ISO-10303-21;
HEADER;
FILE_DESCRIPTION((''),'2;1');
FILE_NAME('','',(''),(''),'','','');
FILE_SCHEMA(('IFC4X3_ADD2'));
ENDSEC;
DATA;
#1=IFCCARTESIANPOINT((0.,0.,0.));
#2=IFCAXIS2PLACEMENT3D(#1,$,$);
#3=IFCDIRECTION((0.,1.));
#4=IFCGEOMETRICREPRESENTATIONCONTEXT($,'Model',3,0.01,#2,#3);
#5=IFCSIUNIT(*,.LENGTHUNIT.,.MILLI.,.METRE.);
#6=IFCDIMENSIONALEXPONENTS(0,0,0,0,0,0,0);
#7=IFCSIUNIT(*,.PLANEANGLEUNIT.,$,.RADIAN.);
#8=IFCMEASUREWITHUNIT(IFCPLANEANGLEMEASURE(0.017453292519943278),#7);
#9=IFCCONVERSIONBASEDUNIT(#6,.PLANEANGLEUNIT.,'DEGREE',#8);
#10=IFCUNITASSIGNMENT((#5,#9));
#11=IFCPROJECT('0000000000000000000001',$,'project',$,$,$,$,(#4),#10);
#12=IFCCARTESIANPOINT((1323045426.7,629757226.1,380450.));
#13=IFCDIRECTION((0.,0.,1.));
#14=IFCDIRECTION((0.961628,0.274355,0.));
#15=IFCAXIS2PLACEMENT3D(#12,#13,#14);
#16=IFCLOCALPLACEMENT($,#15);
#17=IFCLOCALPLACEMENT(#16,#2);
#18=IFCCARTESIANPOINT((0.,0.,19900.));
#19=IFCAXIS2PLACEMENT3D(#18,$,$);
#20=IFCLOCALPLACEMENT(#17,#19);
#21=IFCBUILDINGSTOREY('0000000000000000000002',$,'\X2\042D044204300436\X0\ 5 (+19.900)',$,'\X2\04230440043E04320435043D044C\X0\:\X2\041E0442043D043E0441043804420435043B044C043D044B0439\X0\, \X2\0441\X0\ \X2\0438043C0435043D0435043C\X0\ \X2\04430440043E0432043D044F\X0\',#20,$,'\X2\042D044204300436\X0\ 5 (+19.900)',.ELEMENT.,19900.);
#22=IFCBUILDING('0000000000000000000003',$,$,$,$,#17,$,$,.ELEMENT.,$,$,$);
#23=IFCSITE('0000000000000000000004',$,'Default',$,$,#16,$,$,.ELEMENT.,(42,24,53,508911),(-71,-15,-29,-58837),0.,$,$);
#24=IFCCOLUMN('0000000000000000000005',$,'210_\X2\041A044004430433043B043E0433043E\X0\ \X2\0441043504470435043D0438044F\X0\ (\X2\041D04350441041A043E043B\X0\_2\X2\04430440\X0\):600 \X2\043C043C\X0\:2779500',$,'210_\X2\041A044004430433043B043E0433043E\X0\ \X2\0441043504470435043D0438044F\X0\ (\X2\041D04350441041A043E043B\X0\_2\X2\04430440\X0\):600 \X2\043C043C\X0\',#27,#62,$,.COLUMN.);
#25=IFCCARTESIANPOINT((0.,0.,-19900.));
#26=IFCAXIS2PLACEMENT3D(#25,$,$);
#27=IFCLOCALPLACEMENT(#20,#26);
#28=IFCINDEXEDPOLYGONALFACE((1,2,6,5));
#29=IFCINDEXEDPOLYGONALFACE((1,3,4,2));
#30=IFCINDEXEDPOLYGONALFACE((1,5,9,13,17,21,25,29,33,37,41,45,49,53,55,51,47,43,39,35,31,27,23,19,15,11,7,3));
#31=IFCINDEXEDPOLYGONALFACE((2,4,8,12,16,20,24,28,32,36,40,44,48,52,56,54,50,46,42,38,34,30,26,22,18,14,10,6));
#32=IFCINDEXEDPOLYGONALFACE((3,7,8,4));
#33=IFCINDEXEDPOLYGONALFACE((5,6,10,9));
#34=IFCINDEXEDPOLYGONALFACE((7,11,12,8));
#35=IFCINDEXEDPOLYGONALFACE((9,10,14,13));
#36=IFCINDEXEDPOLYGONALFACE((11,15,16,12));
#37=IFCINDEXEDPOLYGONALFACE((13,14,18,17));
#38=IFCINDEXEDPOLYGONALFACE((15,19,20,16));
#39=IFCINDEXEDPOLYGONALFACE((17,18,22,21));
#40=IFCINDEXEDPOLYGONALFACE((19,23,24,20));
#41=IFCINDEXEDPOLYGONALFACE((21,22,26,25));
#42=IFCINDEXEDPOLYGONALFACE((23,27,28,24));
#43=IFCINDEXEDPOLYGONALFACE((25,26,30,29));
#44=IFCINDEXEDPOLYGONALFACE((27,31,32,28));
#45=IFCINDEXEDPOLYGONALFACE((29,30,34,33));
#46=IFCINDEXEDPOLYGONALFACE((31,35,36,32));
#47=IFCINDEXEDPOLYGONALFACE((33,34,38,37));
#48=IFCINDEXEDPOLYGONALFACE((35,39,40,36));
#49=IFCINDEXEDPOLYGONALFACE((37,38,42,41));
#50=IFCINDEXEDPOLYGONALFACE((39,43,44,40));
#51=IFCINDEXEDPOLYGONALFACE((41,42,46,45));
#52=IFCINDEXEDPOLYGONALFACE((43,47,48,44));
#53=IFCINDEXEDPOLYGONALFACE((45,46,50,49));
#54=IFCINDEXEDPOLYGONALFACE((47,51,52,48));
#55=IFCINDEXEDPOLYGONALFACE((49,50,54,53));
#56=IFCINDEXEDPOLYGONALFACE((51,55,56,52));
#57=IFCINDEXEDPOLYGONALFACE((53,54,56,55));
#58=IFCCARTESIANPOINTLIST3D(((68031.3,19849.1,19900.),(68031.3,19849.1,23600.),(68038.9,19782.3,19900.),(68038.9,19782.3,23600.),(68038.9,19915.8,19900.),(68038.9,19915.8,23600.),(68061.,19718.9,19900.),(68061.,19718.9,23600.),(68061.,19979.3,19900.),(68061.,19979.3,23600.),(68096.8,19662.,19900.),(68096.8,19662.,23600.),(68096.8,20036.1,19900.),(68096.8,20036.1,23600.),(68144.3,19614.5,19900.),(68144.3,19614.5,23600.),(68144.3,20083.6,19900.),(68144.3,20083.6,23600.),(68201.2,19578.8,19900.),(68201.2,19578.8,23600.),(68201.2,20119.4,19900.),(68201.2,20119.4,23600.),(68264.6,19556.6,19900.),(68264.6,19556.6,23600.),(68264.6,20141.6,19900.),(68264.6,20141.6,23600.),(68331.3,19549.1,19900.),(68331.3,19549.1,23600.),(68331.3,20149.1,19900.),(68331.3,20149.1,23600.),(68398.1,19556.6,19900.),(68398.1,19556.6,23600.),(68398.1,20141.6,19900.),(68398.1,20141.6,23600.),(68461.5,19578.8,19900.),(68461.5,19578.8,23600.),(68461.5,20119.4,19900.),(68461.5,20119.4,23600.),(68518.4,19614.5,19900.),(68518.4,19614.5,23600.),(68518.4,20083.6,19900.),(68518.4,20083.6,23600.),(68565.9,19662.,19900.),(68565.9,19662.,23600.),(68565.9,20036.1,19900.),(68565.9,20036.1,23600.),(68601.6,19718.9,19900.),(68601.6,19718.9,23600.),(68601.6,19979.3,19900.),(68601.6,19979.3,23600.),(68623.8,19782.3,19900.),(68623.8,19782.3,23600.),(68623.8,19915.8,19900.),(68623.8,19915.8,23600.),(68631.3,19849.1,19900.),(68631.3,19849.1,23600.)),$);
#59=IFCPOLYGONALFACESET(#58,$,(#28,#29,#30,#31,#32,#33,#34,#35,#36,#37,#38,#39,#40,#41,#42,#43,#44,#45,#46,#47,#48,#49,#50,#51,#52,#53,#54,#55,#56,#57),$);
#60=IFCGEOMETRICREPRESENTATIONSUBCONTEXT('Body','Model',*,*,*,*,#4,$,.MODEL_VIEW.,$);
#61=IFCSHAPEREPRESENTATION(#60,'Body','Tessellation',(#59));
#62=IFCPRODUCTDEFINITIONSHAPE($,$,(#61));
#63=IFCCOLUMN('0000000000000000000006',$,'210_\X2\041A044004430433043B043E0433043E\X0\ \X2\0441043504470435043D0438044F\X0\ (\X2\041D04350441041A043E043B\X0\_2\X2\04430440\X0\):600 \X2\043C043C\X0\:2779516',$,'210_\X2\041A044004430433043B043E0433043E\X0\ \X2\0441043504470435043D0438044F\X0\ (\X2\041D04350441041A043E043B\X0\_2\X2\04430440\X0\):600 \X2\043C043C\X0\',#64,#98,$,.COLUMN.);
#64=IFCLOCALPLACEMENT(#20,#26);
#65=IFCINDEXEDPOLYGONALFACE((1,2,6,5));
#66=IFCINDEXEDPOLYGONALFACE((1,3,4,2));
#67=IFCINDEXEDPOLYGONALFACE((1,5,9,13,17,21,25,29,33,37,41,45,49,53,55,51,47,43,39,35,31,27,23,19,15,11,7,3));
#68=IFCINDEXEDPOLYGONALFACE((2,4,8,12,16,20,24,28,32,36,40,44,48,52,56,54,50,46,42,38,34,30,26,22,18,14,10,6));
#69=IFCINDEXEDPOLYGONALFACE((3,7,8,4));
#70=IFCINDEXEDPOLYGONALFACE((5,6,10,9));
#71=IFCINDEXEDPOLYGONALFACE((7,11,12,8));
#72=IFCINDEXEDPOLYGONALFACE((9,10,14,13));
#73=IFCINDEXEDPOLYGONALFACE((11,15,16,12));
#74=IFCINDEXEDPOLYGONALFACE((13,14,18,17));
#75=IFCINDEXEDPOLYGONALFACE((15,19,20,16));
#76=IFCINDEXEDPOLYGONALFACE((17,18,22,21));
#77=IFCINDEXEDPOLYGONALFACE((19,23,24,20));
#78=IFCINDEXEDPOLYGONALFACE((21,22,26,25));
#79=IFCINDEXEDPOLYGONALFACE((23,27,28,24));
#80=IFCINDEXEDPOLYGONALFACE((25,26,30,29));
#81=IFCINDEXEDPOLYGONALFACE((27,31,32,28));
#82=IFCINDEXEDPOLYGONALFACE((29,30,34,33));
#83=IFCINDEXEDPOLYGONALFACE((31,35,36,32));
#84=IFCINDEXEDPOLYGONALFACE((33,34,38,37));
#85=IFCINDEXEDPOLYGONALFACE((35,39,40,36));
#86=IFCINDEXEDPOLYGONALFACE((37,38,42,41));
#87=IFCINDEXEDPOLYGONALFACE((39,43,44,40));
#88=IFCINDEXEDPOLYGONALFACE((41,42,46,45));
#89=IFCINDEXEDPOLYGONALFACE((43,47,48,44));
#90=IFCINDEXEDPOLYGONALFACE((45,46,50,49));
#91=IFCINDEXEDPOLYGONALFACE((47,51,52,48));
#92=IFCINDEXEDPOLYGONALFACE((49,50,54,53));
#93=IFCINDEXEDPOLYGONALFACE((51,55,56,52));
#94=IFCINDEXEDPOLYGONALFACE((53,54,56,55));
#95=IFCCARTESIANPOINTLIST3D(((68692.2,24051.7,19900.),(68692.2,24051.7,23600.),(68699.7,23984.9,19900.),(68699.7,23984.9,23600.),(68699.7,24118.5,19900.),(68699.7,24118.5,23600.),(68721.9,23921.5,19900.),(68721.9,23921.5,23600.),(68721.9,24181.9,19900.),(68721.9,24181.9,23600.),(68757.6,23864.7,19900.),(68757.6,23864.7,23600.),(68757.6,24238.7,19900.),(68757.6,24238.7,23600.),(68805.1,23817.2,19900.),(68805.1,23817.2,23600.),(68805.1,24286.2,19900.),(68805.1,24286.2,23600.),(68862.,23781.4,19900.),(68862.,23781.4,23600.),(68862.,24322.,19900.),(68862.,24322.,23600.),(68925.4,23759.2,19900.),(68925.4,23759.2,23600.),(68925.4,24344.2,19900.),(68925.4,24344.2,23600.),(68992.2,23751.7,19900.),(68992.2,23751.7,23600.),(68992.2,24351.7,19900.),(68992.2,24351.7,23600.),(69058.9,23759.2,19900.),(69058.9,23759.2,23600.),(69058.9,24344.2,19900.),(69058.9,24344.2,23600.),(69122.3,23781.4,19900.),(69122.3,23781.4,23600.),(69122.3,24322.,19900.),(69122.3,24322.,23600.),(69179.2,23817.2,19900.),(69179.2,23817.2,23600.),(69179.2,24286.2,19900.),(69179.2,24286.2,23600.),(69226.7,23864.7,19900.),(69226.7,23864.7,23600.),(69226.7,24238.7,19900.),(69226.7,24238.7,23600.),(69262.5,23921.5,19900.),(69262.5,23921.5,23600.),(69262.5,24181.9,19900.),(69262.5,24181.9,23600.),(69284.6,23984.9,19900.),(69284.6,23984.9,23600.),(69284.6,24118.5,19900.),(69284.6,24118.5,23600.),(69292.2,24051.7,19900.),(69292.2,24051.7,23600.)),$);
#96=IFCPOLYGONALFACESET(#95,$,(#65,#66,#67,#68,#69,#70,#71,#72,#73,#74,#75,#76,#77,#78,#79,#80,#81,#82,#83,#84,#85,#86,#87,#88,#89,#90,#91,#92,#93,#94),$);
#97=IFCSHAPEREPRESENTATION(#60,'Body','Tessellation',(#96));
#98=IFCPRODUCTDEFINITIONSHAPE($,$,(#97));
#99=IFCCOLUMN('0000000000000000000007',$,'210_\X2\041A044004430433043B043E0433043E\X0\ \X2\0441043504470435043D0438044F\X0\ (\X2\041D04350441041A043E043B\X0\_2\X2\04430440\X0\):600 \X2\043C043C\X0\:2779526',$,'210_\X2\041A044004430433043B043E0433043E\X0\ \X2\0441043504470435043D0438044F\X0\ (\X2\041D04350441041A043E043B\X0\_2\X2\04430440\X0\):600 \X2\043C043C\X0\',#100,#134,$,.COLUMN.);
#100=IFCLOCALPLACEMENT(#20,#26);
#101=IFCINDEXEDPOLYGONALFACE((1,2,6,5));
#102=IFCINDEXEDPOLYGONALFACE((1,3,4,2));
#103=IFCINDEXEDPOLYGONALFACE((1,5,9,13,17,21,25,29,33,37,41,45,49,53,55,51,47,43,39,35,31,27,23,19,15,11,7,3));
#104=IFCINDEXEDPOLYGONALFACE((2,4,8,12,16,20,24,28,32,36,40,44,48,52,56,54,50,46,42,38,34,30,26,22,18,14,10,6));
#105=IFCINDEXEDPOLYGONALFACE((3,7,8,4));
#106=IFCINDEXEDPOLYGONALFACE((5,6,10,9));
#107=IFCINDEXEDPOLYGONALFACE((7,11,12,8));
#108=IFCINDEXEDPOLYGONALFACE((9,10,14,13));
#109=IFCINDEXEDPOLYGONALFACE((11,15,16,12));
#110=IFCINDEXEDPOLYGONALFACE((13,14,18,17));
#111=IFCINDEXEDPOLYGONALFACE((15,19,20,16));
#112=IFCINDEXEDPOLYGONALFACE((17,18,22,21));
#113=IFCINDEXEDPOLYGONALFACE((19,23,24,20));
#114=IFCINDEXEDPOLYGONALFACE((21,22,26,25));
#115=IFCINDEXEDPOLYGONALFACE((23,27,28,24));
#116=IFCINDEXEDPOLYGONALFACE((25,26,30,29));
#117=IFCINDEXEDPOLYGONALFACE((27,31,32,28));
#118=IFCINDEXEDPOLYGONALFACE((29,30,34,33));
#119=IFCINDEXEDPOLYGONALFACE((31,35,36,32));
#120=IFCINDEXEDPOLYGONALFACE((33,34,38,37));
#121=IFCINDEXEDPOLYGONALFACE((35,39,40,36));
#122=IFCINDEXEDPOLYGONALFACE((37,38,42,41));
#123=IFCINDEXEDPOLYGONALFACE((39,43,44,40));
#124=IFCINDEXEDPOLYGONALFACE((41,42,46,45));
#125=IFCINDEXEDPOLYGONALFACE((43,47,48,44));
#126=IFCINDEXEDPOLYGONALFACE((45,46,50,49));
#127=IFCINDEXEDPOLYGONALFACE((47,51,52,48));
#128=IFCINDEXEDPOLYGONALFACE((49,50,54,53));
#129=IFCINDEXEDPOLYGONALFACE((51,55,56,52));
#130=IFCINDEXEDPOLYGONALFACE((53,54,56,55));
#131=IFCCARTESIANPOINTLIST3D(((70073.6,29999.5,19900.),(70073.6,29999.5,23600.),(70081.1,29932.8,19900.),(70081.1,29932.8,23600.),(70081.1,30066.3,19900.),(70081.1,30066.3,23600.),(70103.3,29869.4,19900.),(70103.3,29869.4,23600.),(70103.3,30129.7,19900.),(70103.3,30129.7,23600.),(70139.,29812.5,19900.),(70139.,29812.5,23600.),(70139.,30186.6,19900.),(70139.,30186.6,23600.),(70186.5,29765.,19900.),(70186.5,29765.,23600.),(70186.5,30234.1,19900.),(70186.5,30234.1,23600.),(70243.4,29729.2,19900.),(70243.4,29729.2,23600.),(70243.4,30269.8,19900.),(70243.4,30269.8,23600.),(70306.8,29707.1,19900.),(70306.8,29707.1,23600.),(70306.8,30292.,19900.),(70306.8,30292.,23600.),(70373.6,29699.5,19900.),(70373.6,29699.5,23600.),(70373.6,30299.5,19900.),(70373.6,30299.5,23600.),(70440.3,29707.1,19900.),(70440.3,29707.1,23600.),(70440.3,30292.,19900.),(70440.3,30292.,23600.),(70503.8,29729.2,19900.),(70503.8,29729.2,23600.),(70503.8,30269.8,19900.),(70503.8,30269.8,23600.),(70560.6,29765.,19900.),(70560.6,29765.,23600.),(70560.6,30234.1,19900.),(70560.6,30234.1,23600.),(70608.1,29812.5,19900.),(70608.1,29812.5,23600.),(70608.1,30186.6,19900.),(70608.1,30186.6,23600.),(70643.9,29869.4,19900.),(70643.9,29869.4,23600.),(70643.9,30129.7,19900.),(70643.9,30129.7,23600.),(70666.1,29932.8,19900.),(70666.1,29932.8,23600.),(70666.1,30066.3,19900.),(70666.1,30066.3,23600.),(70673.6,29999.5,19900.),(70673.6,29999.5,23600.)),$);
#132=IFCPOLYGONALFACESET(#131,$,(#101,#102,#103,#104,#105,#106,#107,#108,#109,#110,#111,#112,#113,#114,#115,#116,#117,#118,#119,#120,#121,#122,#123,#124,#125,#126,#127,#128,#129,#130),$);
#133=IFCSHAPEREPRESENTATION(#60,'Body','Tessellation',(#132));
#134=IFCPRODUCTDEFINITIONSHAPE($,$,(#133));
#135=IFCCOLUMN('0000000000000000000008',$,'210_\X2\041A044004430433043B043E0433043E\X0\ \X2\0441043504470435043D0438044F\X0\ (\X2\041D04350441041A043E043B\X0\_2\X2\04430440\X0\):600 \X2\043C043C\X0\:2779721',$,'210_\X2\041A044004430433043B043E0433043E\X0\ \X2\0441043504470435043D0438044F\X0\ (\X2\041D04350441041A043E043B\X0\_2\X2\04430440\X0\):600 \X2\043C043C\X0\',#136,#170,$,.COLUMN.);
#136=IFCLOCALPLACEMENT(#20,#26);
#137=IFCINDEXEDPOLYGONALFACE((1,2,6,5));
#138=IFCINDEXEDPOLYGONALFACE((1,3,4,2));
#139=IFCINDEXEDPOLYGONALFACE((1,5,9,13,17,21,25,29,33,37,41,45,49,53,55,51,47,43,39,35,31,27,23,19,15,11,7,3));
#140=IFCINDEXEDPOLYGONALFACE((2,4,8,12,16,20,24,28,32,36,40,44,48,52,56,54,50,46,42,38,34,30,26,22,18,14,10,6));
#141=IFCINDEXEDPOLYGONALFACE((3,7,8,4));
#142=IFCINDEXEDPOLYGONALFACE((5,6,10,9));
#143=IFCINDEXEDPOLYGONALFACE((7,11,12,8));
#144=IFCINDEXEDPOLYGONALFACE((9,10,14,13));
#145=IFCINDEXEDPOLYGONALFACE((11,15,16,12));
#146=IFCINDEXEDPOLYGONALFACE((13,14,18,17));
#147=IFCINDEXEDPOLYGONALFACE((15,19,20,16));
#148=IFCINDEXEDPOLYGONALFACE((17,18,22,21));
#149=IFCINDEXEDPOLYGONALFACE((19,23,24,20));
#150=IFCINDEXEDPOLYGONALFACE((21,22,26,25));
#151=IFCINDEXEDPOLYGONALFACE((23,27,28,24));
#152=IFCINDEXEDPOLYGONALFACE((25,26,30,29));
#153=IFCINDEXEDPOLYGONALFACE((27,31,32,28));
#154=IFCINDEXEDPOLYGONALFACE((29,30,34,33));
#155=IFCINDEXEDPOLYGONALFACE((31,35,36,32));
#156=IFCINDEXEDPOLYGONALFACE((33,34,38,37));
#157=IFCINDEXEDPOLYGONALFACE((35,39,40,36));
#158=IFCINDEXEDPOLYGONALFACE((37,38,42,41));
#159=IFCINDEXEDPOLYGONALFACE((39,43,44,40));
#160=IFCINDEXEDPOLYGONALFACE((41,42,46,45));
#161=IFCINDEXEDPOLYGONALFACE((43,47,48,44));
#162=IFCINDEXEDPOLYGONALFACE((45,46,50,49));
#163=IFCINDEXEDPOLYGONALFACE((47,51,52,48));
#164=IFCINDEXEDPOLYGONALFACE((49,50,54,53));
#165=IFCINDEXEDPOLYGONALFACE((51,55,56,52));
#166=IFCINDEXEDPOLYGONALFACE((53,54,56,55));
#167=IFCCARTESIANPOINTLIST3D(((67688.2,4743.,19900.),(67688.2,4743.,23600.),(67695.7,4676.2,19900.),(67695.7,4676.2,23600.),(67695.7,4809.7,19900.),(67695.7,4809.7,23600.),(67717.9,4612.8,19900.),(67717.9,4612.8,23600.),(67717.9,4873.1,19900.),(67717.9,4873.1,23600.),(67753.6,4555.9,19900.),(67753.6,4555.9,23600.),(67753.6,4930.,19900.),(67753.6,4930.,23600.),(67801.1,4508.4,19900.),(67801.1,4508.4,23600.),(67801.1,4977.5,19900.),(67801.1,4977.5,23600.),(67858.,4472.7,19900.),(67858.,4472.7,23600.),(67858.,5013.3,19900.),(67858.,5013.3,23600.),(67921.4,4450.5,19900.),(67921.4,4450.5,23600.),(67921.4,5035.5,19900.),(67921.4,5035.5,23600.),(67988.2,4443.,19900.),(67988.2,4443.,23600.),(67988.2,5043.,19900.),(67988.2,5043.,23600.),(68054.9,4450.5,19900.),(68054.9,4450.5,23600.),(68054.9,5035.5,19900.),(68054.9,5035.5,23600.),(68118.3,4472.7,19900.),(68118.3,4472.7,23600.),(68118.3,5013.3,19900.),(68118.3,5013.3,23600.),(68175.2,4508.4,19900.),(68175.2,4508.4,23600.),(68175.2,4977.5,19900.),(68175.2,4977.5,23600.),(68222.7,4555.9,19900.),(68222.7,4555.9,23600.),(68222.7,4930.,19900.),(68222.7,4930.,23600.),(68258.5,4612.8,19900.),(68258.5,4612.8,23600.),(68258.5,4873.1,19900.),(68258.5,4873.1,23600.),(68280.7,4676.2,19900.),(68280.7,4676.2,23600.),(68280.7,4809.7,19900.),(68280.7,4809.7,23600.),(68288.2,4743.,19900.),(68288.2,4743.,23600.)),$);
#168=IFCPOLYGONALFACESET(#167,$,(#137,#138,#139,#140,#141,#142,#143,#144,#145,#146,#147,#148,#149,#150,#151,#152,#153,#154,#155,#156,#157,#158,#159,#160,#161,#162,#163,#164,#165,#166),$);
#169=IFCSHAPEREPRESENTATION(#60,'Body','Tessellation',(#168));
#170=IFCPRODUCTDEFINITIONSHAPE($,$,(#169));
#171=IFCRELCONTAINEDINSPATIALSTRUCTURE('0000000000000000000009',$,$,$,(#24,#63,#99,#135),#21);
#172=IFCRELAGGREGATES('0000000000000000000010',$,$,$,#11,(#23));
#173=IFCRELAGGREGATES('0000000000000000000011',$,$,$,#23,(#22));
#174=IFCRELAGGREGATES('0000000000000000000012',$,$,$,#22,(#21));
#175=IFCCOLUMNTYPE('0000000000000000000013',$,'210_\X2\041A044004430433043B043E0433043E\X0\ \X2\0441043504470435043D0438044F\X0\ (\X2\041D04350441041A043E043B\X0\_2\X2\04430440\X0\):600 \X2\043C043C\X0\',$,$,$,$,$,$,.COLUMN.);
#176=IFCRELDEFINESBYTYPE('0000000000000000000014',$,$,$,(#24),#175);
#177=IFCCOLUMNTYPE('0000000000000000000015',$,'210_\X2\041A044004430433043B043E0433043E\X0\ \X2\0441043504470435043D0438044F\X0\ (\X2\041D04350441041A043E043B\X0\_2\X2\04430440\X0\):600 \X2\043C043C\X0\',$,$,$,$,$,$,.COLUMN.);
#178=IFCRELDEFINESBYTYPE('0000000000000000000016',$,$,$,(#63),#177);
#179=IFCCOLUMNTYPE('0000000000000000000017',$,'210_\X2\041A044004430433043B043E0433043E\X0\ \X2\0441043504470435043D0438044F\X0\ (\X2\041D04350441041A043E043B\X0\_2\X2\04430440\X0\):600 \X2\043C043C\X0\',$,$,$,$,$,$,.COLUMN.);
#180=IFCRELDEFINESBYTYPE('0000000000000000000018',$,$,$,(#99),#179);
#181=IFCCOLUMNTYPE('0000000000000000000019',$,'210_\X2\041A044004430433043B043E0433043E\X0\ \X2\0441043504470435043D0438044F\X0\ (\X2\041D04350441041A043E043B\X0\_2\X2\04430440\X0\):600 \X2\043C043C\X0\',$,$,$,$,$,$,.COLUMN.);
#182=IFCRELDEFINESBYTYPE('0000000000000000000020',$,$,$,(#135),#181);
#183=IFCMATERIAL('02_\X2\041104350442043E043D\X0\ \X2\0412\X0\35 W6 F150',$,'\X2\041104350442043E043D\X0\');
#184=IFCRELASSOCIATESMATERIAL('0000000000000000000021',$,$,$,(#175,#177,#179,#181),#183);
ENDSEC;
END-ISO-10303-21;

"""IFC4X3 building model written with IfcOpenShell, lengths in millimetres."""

from ifc_helpers import new_model, entity, si_unit, converted_unit, direction, frame, frame_2d, origin, origin_2d_with_axis, place, context, subcontext, project, spatial, circle, extrude, source, transform, mapped, material, material_profile, profile_set, type_object, type_shapes, element, save


model = new_model("IFC4X3")

# Units and contexts
model_context = context("Model", 3, precision=0.01, world=origin(), true_north=direction((0.0, 1.0)))
body_context = subcontext(model_context, "Body", "Model", "MODEL_VIEW")
ifc_project = project(units=[si_unit("LENGTHUNIT", "METRE", prefix="MILLI"), converted_unit("PLANEANGLEUNIT", "DEGREE", entity("IfcPlaneAngleMeasure", 0.017453292519943278), si_unit("PLANEANGLEUNIT", "RADIAN"), dimensions=[0, 0, 0, 0, 0, 0, 0])], contexts=[model_context])

# Site, building, storey
site_placement = place(None, frame((1323045426.7, 629757226.1, 380450.0), z_axis=(0.0, 0.0, 1.0), x_axis=(0.961628, 0.274355, 0.0)))
site = spatial("IfcSite", under=ifc_project, at=site_placement, Name="Default", CompositionType="ELEMENT", RefLatitude=(42, 24, 53, 508911), RefLongitude=(-71, -15, -29, -58837), RefElevation=0.0)
building_placement = place(site_placement, origin())
building = spatial("IfcBuilding", under=site, at=building_placement, CompositionType="ELEMENT")
storey_placement = place(building_placement, frame((0.0, 0.0, 19900.0)))
storey = spatial("IfcBuildingStorey", under=building, at=storey_placement, Name="Этаж 5 (+19.900)", ObjectType="Уровень:Относительный, с именем уровня", LongName="Этаж 5 (+19.900)", CompositionType="ELEMENT", Elevation=19900.0)

# Columns
ifc_material = material(Name="02_Бетон В35 W6 F150", Category="Бетон")
ifc_material_profile = material_profile(ifc_material, circle(Radius=300.0, at=origin_2d_with_axis()), Name="600 мм")
ifc_profile_set = profile_set([ifc_material_profile], Name="600 мм")
column_type_1 = type_object("IfcColumnType", Name="210_Круглого сечения (НесКол_2ур):600 мм", PredefinedType="COLUMN", material=ifc_profile_set)
shared_shape_1 = source(origin(), body_context, "Body", "SweptSolid", [
    extrude(circle(Radius=300.0, at=origin_2d_with_axis()), frame((68331.3, 19849.1, 19900.0)), (0.0, 0.0, 1.0), 3700.0),
])
type_shapes(column_type_1, [shared_shape_1])
column_1_placement = place(storey_placement, frame((0.0, 0.0, -19900.0)))
element("IfcColumn", 1, at=column_1_placement, inside=storey, type_object=column_type_1, Name="210_Круглого сечения (НесКол_2ур):600 мм:2779500", ObjectType="210_Круглого сечения (НесКол_2ур):600 мм", PredefinedType="COLUMN", context=body_context, shape_type="MappedRepresentation", body=[
    mapped(shared_shape_1, transform((0.0, 0.0, 0.0), scale=1.0)),
])
column_type_2 = type_object("IfcColumnType", Name="210_Круглого сечения (НесКол_2ур):600 мм", PredefinedType="COLUMN", material=ifc_profile_set)
shared_shape_2 = source(origin(), body_context, "Body", "SweptSolid", [
    extrude(circle(Radius=300.0, at=origin_2d_with_axis()), frame((68992.2, 24051.7, 19900.0)), (0.0, 0.0, 1.0), 3700.0),
])
type_shapes(column_type_2, [shared_shape_2])
column_2_placement = place(storey_placement, frame((0.0, 0.0, -19900.0)))
element("IfcColumn", 2, at=column_2_placement, inside=storey, type_object=column_type_2, Name="210_Круглого сечения (НесКол_2ур):600 мм:2779516", ObjectType="210_Круглого сечения (НесКол_2ур):600 мм", PredefinedType="COLUMN", context=body_context, shape_type="MappedRepresentation", body=[
    mapped(shared_shape_2, transform((0.0, 0.0, 0.0), scale=1.0)),
])
column_type_3 = type_object("IfcColumnType", Name="210_Круглого сечения (НесКол_2ур):600 мм", PredefinedType="COLUMN", material=ifc_profile_set)
shared_shape_3 = source(origin(), body_context, "Body", "SweptSolid", [
    extrude(circle(Radius=300.0, at=origin_2d_with_axis()), frame((70373.6, 29999.5, 19900.0)), (0.0, 0.0, 1.0), 3700.0),
])
type_shapes(column_type_3, [shared_shape_3])
column_3_placement = place(storey_placement, frame((0.0, 0.0, -19900.0)))
element("IfcColumn", 3, at=column_3_placement, inside=storey, type_object=column_type_3, Name="210_Круглого сечения (НесКол_2ур):600 мм:2779526", ObjectType="210_Круглого сечения (НесКол_2ур):600 мм", PredefinedType="COLUMN", context=body_context, shape_type="MappedRepresentation", body=[
    mapped(shared_shape_3, transform((0.0, 0.0, 0.0), scale=1.0)),
])
column_type_4 = type_object("IfcColumnType", Name="210_Круглого сечения (НесКол_2ур):600 мм", PredefinedType="COLUMN", material=ifc_profile_set)
shared_shape_4 = source(origin(), body_context, "Body", "SweptSolid", [
    extrude(circle(Radius=300.0, at=frame_2d((0.0, 0.0), x_axis=(1.0, 0.0))), frame((67988.2, 4743.0, 19900.0)), (0.0, 0.0, 1.0), 3700.0),
])
type_shapes(column_type_4, [shared_shape_4])
column_4_placement = place(storey_placement, frame((0.0, 0.0, -19900.0)))
element("IfcColumn", 4, at=column_4_placement, inside=storey, type_object=column_type_4, Name="210_Круглого сечения (НесКол_2ур):600 мм:2779721", ObjectType="210_Круглого сечения (НесКол_2ур):600 мм", PredefinedType="COLUMN", context=body_context, shape_type="MappedRepresentation", body=[
    mapped(shared_shape_4, transform((0.0, 0.0, 0.0), scale=1.0)),
])

save(model, "model.ifc")
